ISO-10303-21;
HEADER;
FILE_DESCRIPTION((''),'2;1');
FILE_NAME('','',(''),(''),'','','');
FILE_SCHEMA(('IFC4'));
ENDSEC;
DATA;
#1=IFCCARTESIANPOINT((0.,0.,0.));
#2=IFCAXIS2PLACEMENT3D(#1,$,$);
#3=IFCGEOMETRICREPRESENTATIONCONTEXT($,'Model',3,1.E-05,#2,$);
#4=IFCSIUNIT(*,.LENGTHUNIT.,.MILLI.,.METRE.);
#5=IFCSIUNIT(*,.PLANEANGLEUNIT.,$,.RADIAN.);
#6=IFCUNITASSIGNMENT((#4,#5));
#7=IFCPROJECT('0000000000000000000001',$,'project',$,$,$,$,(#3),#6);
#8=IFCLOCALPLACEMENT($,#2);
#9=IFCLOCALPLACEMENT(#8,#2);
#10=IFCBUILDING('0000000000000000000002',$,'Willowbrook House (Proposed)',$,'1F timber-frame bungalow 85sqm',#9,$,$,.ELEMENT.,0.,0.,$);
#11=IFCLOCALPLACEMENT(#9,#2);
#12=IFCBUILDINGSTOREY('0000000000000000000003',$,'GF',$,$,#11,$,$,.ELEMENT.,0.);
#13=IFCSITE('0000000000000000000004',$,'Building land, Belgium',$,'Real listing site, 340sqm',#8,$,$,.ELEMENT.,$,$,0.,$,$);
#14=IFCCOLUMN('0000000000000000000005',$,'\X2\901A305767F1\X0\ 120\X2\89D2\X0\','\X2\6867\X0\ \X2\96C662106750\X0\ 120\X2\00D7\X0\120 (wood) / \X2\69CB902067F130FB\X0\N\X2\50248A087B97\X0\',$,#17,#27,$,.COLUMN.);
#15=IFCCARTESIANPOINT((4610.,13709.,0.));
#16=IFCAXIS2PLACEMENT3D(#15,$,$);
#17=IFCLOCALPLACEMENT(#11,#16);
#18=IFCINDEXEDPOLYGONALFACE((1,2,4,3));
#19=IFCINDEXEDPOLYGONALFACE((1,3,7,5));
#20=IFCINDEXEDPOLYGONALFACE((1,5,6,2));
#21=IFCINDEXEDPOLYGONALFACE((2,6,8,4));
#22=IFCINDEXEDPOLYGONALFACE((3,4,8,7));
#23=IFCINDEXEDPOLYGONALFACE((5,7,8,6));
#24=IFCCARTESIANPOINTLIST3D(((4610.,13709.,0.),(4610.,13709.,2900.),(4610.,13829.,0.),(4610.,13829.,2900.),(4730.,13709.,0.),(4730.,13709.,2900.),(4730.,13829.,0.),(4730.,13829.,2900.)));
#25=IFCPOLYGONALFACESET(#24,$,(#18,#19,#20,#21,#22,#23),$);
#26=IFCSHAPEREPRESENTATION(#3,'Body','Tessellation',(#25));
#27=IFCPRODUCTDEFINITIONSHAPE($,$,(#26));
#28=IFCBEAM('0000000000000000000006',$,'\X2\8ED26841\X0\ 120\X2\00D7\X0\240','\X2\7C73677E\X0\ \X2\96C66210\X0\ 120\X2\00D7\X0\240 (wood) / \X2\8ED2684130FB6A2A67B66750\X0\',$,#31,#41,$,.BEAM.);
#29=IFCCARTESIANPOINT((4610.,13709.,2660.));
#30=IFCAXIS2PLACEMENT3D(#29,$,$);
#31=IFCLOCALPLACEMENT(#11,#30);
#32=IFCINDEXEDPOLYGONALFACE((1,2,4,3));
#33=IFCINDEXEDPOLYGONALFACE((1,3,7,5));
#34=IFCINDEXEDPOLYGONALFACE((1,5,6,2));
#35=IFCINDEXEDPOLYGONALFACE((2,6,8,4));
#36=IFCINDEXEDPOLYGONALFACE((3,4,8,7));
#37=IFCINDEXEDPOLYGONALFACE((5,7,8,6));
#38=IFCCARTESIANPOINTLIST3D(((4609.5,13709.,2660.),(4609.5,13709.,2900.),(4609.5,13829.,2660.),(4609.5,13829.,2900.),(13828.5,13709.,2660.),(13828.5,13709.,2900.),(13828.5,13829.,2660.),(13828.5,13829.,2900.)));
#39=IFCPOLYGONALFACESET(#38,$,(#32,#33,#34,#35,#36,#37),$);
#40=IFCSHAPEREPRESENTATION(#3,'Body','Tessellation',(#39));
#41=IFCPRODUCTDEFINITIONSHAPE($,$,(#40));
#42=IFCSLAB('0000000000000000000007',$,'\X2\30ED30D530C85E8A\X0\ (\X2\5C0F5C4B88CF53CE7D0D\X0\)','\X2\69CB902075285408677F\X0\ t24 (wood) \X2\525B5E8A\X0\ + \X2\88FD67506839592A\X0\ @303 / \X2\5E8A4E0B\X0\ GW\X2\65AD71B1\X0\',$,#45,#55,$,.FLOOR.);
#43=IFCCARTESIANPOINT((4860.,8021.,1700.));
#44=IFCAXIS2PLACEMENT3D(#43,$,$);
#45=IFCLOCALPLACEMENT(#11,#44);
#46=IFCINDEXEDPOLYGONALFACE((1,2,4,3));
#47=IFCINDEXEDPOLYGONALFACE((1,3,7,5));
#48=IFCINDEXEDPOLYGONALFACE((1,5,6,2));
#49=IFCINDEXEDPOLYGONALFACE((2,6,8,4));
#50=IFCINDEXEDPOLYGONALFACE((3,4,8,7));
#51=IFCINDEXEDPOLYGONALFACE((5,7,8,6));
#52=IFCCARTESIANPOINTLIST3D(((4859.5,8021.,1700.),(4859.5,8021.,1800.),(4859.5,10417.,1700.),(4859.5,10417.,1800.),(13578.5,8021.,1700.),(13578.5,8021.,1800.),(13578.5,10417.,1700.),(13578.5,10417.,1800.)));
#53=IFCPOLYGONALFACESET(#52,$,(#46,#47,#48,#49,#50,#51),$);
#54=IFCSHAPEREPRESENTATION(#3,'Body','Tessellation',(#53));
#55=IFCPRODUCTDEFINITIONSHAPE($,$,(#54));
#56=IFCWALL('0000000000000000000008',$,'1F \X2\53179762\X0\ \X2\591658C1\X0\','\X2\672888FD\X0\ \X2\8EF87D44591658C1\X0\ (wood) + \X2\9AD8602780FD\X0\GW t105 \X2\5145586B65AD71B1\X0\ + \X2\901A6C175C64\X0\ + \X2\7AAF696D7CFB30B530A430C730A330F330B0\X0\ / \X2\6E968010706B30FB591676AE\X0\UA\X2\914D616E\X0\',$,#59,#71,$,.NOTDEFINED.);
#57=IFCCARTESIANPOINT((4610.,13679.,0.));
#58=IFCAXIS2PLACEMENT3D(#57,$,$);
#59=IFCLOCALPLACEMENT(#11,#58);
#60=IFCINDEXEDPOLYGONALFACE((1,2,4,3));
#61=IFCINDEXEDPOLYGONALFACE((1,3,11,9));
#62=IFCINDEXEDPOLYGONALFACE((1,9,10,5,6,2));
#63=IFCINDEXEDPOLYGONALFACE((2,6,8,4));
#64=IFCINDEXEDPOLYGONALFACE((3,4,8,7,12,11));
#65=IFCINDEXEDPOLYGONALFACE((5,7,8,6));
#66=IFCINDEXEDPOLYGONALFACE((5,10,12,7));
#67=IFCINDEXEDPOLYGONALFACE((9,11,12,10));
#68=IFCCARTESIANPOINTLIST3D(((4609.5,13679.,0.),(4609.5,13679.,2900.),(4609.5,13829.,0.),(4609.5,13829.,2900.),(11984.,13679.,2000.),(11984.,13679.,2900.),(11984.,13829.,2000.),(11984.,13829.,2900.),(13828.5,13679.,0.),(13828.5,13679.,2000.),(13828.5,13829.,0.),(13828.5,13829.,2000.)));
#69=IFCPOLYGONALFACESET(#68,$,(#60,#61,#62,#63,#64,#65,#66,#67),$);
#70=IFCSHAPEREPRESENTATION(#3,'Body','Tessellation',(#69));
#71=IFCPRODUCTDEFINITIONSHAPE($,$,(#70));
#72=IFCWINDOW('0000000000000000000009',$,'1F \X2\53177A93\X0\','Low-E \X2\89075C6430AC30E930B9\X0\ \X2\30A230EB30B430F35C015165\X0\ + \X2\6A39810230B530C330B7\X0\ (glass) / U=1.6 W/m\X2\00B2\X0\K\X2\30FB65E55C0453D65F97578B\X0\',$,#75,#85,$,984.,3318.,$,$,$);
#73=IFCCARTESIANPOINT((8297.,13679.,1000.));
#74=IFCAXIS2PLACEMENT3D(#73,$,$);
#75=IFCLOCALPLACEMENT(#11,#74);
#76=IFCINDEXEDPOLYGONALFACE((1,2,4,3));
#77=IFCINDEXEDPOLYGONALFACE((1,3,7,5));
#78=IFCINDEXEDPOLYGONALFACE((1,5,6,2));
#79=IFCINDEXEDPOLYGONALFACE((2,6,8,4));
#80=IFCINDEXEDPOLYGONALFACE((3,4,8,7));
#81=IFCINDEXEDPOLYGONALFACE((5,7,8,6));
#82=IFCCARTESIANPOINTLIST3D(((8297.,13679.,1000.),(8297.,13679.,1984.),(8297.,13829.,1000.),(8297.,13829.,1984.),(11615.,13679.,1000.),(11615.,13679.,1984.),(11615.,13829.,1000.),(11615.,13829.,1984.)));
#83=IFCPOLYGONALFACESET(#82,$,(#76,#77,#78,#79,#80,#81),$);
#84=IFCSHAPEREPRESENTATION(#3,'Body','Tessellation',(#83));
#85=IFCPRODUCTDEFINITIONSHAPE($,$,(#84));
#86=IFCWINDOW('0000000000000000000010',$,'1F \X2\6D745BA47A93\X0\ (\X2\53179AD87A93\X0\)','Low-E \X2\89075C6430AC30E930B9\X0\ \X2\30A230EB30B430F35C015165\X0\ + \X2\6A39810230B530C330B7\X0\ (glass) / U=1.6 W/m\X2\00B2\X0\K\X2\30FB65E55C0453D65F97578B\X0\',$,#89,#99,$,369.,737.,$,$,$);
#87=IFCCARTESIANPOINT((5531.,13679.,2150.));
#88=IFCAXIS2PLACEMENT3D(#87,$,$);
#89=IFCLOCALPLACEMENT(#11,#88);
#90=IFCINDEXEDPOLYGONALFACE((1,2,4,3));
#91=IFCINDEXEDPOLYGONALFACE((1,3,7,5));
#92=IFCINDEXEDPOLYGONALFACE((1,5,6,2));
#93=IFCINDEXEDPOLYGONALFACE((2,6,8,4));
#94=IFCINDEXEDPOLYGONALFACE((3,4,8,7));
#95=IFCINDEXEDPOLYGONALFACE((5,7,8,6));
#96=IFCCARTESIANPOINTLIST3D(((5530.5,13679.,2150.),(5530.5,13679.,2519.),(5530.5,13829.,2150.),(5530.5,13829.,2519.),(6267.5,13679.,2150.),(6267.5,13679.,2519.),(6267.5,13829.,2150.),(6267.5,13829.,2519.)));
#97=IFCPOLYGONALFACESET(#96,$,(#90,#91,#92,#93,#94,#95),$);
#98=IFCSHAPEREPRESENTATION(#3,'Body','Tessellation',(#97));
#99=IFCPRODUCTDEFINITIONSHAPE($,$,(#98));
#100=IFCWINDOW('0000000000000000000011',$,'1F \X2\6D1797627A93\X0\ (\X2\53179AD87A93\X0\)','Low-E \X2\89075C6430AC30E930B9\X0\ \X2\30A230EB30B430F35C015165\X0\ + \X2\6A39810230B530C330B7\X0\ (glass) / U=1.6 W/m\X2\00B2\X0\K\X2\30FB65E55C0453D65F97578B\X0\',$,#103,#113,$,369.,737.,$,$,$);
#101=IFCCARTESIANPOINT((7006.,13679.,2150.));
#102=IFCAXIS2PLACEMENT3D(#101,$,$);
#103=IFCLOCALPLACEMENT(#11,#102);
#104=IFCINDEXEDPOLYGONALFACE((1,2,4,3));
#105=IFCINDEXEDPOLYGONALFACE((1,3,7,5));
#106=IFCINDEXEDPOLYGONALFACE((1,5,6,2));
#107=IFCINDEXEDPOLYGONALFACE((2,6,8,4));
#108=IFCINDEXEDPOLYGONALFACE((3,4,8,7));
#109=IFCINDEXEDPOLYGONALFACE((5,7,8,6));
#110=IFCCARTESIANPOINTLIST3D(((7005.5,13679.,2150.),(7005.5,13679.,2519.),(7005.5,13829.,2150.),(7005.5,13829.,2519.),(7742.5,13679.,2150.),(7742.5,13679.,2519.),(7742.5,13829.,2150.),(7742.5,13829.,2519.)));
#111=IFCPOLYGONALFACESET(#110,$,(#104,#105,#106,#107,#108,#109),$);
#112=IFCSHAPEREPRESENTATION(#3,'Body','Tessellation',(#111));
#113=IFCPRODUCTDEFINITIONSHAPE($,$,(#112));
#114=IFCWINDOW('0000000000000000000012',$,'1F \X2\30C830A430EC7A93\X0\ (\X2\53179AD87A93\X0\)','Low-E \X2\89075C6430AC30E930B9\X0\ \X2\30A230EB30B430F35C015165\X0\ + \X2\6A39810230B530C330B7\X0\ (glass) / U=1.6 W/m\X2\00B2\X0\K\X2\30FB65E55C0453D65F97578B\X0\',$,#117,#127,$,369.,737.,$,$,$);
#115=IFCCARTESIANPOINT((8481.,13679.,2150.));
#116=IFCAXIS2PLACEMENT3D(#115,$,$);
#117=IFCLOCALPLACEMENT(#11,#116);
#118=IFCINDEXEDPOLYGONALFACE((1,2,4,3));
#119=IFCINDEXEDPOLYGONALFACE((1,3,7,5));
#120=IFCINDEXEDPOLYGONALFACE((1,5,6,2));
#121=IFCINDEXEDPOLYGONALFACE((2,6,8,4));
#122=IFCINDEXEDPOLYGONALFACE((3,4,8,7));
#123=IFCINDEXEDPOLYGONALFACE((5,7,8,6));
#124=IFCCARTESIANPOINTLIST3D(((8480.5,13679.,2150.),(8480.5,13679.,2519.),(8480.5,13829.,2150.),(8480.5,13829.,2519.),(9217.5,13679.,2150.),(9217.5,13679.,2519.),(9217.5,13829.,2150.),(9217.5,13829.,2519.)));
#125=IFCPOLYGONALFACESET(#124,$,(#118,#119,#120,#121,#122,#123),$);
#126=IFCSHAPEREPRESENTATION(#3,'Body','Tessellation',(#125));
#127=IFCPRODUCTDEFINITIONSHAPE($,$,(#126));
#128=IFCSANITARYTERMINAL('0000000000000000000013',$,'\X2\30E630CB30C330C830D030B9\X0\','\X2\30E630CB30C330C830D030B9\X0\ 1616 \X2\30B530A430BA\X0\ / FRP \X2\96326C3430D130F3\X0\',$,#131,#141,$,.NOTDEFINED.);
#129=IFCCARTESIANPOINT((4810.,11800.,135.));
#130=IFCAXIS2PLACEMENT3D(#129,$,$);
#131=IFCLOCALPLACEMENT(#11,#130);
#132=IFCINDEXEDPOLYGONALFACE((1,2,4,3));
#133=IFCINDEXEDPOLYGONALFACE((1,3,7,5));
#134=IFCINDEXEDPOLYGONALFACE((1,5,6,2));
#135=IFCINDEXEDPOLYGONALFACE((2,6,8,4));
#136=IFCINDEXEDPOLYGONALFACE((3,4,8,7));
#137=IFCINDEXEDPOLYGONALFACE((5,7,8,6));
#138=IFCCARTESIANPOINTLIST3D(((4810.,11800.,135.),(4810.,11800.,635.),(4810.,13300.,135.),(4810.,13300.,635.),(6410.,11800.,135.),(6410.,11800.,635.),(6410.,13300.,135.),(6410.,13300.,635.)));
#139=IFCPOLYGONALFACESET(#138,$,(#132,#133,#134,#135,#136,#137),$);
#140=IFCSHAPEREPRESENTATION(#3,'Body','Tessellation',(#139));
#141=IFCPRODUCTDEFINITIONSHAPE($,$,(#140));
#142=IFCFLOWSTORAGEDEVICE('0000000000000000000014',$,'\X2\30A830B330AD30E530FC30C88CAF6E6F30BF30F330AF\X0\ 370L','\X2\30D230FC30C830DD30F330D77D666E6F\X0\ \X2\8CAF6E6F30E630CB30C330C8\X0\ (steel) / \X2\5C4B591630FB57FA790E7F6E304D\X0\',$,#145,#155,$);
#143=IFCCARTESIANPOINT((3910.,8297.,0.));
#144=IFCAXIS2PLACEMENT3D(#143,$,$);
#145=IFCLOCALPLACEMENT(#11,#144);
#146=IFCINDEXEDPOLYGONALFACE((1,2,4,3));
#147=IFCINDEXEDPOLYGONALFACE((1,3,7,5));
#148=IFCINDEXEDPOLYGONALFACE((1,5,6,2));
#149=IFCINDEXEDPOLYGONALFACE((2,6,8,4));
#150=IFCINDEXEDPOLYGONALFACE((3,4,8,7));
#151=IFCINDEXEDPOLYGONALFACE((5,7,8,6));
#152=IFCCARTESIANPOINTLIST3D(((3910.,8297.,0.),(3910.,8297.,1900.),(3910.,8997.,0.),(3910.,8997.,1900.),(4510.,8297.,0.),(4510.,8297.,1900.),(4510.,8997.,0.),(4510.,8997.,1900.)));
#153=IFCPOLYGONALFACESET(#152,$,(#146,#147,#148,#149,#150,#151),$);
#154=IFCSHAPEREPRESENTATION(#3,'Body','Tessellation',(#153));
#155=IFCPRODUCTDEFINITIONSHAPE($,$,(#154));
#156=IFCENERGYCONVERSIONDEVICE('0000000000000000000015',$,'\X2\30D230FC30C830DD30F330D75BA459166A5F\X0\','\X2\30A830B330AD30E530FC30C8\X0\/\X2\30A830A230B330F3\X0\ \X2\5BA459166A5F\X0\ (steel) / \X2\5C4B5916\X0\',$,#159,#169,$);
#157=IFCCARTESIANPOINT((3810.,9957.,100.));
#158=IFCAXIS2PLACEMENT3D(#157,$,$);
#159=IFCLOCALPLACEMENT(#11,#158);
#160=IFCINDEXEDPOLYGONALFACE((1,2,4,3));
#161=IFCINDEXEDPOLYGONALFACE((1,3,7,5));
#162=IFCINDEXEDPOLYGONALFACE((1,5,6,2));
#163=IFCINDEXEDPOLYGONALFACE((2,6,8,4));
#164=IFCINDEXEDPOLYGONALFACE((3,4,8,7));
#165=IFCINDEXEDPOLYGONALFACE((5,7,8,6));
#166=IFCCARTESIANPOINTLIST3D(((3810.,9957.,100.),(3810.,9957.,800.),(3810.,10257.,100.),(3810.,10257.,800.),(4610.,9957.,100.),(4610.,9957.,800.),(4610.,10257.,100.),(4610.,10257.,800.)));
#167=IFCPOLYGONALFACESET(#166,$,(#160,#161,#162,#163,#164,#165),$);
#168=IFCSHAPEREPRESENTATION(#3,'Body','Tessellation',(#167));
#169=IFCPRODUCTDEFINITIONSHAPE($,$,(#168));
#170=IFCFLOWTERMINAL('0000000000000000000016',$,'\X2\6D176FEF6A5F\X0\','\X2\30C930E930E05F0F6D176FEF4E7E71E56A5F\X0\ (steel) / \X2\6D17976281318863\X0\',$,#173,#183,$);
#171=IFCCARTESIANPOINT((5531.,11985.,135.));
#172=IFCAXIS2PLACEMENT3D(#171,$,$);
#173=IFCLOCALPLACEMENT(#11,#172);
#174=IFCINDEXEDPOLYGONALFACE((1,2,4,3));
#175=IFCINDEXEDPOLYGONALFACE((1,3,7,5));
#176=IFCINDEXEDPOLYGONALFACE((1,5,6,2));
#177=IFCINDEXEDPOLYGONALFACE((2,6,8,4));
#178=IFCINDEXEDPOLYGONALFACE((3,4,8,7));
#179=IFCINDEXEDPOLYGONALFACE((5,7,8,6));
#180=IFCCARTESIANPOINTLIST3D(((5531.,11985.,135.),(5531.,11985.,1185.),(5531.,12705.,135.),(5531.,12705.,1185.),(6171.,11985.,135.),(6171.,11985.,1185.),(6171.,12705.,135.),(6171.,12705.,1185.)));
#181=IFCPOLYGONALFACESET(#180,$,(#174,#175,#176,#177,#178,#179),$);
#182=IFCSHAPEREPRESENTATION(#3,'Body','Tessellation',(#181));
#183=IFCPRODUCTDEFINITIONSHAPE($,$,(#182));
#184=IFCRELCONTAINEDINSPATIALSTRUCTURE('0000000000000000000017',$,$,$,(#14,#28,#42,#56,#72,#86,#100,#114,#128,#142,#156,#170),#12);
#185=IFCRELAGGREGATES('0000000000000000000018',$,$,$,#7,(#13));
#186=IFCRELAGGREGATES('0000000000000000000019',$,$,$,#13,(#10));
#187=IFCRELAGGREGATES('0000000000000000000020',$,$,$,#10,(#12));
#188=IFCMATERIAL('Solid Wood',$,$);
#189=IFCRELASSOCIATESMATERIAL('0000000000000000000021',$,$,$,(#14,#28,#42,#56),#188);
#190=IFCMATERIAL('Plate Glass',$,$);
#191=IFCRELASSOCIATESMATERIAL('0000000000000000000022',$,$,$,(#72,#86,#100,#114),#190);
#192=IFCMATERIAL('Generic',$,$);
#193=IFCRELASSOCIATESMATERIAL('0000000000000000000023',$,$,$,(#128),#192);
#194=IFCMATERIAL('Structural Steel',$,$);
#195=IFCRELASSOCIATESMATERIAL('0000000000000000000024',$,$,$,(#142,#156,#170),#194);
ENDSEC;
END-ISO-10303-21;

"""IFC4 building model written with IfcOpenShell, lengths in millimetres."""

from ifc_helpers import new_model, si_unit, frame, frame_2d, origin, place, context, project, spatial, rectangle, extrude, material, element, fill, save


model = new_model("IFC4")

# Units and contexts
model_context = context("Model", 3, precision=1e-05, world=origin())
ifc_project = project(units=[si_unit("LENGTHUNIT", "METRE", prefix="MILLI"), si_unit("PLANEANGLEUNIT", "RADIAN")], contexts=[model_context])

# Site, building, storey
site_placement = place(None, origin())
site = spatial("IfcSite", under=ifc_project, at=site_placement, Name="Building land, Belgium", ObjectType="Real listing site, 340sqm", CompositionType="ELEMENT", RefElevation=0.0)
building_placement = place(site_placement, origin())
building = spatial("IfcBuilding", under=site, at=building_placement, Name="Willowbrook House (Proposed)", ObjectType="1F timber-frame bungalow 85sqm", CompositionType="ELEMENT", ElevationOfRefHeight=0.0, ElevationOfTerrain=0.0)
storey_placement = place(building_placement, origin())
storey = spatial("IfcBuildingStorey", under=building, at=storey_placement, Name="GF", CompositionType="ELEMENT", Elevation=0.0)

# Column
ifc_material_1 = material(Name="Solid Wood")
column_1_placement = place(storey_placement, frame((4610.0, 13709.0, 0.0)))
element("IfcColumn", 1, at=column_1_placement, inside=storey, material=ifc_material_1, Name="通し柱 120角", Description="桧 集成材 120×120 (wood) / 構造柱・N値計算", PredefinedType="COLUMN", context=model_context, shape_type="SweptSolid", body=[
    extrude(rectangle(XDim=120.0, YDim=120.0, at=frame_2d((60.0, 60.0))), frame((4610.0, 13709.0, 0.0)), (0.0, 0.0, 1.0), 2900.0),
])

# Beam
beam_1_placement = place(storey_placement, frame((4610.0, 13709.0, 2660.0)))
element("IfcBeam", 2, at=beam_1_placement, inside=storey, material=ifc_material_1, Name="軒桁 120×240", Description="米松 集成 120×240 (wood) / 軒桁・横架材", PredefinedType="BEAM", context=model_context, shape_type="SweptSolid", body=[
    extrude(rectangle(XDim=9219.0, YDim=120.0, at=frame_2d((4609.0, 60.0))), frame((4610.0, 13709.0, 2660.0)), (0.0, 0.0, 1.0), 240.0),
])

# Slab
slab_placement = place(storey_placement, frame((4860.0, 8021.0, 1700.0)))
element("IfcSlab", 3, at=slab_placement, inside=storey, material=ifc_material_1, Name="ロフト床 (小屋裏収納)", Description="構造用合板 t24 (wood) 剛床 + 製材根太 @303 / 床下 GW断熱", PredefinedType="FLOOR", context=model_context, shape_type="SweptSolid", body=[
    extrude(rectangle(XDim=8719.0, YDim=2396.0, at=frame_2d((4359.0, 1198.0))), frame((4860.0, 8021.0, 1700.0)), (0.0, 0.0, 1.0), 100.0),
])

# Wall, openings, windows
wall_1_placement = place(storey_placement, frame((4610.0, 13679.0, 0.0)))
wall_1 = element("IfcWall", 4, at=wall_1_placement, inside=storey, material=ifc_material_1, Name="1F 北面 外壁", Description="木製 軸組外壁 (wood) + 高性能GW t105 充填断熱 + 通気層 + 窯業系サイディング / 準耐火・外皮UA配慮", PredefinedType="NOTDEFINED", context=model_context, shape_type="SweptSolid", body=[
    extrude(rectangle(XDim=9219.0, YDim=150.0, at=frame_2d((4609.0, 75.0))), frame((4610.0, 13679.0, 0.0)), (0.0, 0.0, 1.0), 2900.0),
])
opening_1_placement = place(storey_placement, frame((8297.0, 13679.0, 1000.0)))
opening_1 = element("IfcOpeningElement", 5, at=opening_1_placement, cuts=wall_1, PredefinedType="NOTDEFINED", context=model_context, shape_type="SweptSolid", body=[
    extrude(rectangle(XDim=3318.0, YDim=150.0, at=frame_2d((1659.0, 75.0))), frame((8297.0, 13679.0, 1000.0)), (0.0, 0.0, 1.0), 984.0),
])
opening_2_placement = place(storey_placement, frame((5531.0, 13679.0, 2150.0)))
opening_2 = element("IfcOpeningElement", 6, at=opening_2_placement, cuts=wall_1, PredefinedType="NOTDEFINED", context=model_context, shape_type="SweptSolid", body=[
    extrude(rectangle(XDim=737.0, YDim=150.0, at=frame_2d((368.0, 75.0))), frame((5531.0, 13679.0, 2150.0)), (0.0, 0.0, 1.0), 369.0),
])
opening_3_placement = place(storey_placement, frame((7006.0, 13679.0, 2150.0)))
opening_3 = element("IfcOpeningElement", 7, at=opening_3_placement, cuts=wall_1, PredefinedType="NOTDEFINED", context=model_context, shape_type="SweptSolid", body=[
    extrude(rectangle(XDim=737.0, YDim=150.0, at=frame_2d((368.0, 75.0))), frame((7006.0, 13679.0, 2150.0)), (0.0, 0.0, 1.0), 369.0),
])
opening_4_placement = place(storey_placement, frame((8481.0, 13679.0, 2150.0)))
opening_4 = element("IfcOpeningElement", 8, at=opening_4_placement, cuts=wall_1, PredefinedType="NOTDEFINED", context=model_context, shape_type="SweptSolid", body=[
    extrude(rectangle(XDim=737.0, YDim=150.0, at=frame_2d((368.0, 75.0))), frame((8481.0, 13679.0, 2150.0)), (0.0, 0.0, 1.0), 369.0),
])
ifc_material_2 = material(Name="Plate Glass")
window_1_placement = place(storey_placement, frame((8297.0, 13679.0, 1000.0)))
window_1 = element("IfcWindow", 9, at=window_1_placement, inside=storey, material=ifc_material_2, Name="1F 北窓", Description="Low-E 複層ガラス アルゴン封入 + 樹脂サッシ (glass) / U=1.6 W/m²K・日射取得型", OverallHeight=984.0, OverallWidth=3318.0, context=model_context, shape_type="SweptSolid", body=[
    extrude(rectangle(XDim=3318.0, YDim=150.0, at=frame_2d((1659.0, 75.0))), frame((8297.0, 13679.0, 1000.0)), (0.0, 0.0, 1.0), 984.0),
])
fill(opening_1, window_1)
window_2_placement = place(storey_placement, frame((5531.0, 13679.0, 2150.0)))
window_2 = element("IfcWindow", 10, at=window_2_placement, inside=storey, material=ifc_material_2, Name="1F 浴室窓 (北高窓)", Description="Low-E 複層ガラス アルゴン封入 + 樹脂サッシ (glass) / U=1.6 W/m²K・日射取得型", OverallHeight=369.0, OverallWidth=737.0, context=model_context, shape_type="SweptSolid", body=[
    extrude(rectangle(XDim=737.0, YDim=150.0, at=frame_2d((368.0, 75.0))), frame((5531.0, 13679.0, 2150.0)), (0.0, 0.0, 1.0), 369.0),
])
fill(opening_2, window_2)
window_3_placement = place(storey_placement, frame((7006.0, 13679.0, 2150.0)))
window_3 = element("IfcWindow", 11, at=window_3_placement, inside=storey, material=ifc_material_2, Name="1F 洗面窓 (北高窓)", Description="Low-E 複層ガラス アルゴン封入 + 樹脂サッシ (glass) / U=1.6 W/m²K・日射取得型", OverallHeight=369.0, OverallWidth=737.0, context=model_context, shape_type="SweptSolid", body=[
    extrude(rectangle(XDim=737.0, YDim=150.0, at=frame_2d((368.0, 75.0))), frame((7006.0, 13679.0, 2150.0)), (0.0, 0.0, 1.0), 369.0),
])
fill(opening_3, window_3)
window_4_placement = place(storey_placement, frame((8481.0, 13679.0, 2150.0)))
window_4 = element("IfcWindow", 12, at=window_4_placement, inside=storey, material=ifc_material_2, Name="1F トイレ窓 (北高窓)", Description="Low-E 複層ガラス アルゴン封入 + 樹脂サッシ (glass) / U=1.6 W/m²K・日射取得型", OverallHeight=369.0, OverallWidth=737.0, context=model_context, shape_type="SweptSolid", body=[
    extrude(rectangle(XDim=737.0, YDim=150.0, at=frame_2d((368.0, 75.0))), frame((8481.0, 13679.0, 2150.0)), (0.0, 0.0, 1.0), 369.0),
])
fill(opening_4, window_4)

# Sanitary terminal
ifc_material_3 = material(Name="Generic")
sanitary_terminal_placement = place(storey_placement, frame((4810.0, 11800.0, 135.0)))
element("IfcSanitaryTerminal", 13, at=sanitary_terminal_placement, inside=storey, material=ifc_material_3, Name="ユニットバス", Description="ユニットバス 1616 サイズ / FRP 防水パン", PredefinedType="NOTDEFINED", context=model_context, shape_type="SweptSolid", body=[
    extrude(rectangle(XDim=1600.0, YDim=1500.0, at=frame_2d((800.0, 750.0))), frame((4810.0, 11800.0, 135.0)), (0.0, 0.0, 1.0), 500.0),
])

# Flow storage device
ifc_material_4 = material(Name="Structural Steel")
flow_storage_device_placement = place(storey_placement, frame((3910.0, 8297.0, 0.0)))
element("IfcFlowStorageDevice", 14, at=flow_storage_device_placement, inside=storey, material=ifc_material_4, Name="エコキュート貯湯タンク 370L", Description="ヒートポンプ給湯 貯湯ユニット (steel) / 屋外・基礎置き", context=model_context, shape_type="SweptSolid", body=[
    extrude(rectangle(XDim=600.0, YDim=700.0, at=frame_2d((300.0, 350.0))), frame((3910.0, 8297.0, 0.0)), (0.0, 0.0, 1.0), 1900.0),
])

# Energy conversion device
energy_conversion_device_placement = place(storey_placement, frame((3810.0, 9957.0, 100.0)))
element("IfcEnergyConversionDevice", 15, at=energy_conversion_device_placement, inside=storey, material=ifc_material_4, Name="ヒートポンプ室外機", Description="エコキュート/エアコン 室外機 (steel) / 屋外", context=model_context, shape_type="SweptSolid", body=[
    extrude(rectangle(XDim=800.0, YDim=300.0, at=frame_2d((400.0, 150.0))), frame((3810.0, 9957.0, 100.0)), (0.0, 0.0, 1.0), 700.0),
])

# Flow terminal
flow_terminal_placement = place(storey_placement, frame((5531.0, 11985.0, 135.0)))
element("IfcFlowTerminal", 16, at=flow_terminal_placement, inside=storey, material=ifc_material_4, Name="洗濯機", Description="ドラム式洗濯乾燥機 (steel) / 洗面脱衣", context=model_context, shape_type="SweptSolid", body=[
    extrude(rectangle(XDim=640.0, YDim=720.0, at=frame_2d((320.0, 360.0))), frame((5531.0, 11985.0, 135.0)), (0.0, 0.0, 1.0), 1050.0),
])

save(model, "model.ifc")
